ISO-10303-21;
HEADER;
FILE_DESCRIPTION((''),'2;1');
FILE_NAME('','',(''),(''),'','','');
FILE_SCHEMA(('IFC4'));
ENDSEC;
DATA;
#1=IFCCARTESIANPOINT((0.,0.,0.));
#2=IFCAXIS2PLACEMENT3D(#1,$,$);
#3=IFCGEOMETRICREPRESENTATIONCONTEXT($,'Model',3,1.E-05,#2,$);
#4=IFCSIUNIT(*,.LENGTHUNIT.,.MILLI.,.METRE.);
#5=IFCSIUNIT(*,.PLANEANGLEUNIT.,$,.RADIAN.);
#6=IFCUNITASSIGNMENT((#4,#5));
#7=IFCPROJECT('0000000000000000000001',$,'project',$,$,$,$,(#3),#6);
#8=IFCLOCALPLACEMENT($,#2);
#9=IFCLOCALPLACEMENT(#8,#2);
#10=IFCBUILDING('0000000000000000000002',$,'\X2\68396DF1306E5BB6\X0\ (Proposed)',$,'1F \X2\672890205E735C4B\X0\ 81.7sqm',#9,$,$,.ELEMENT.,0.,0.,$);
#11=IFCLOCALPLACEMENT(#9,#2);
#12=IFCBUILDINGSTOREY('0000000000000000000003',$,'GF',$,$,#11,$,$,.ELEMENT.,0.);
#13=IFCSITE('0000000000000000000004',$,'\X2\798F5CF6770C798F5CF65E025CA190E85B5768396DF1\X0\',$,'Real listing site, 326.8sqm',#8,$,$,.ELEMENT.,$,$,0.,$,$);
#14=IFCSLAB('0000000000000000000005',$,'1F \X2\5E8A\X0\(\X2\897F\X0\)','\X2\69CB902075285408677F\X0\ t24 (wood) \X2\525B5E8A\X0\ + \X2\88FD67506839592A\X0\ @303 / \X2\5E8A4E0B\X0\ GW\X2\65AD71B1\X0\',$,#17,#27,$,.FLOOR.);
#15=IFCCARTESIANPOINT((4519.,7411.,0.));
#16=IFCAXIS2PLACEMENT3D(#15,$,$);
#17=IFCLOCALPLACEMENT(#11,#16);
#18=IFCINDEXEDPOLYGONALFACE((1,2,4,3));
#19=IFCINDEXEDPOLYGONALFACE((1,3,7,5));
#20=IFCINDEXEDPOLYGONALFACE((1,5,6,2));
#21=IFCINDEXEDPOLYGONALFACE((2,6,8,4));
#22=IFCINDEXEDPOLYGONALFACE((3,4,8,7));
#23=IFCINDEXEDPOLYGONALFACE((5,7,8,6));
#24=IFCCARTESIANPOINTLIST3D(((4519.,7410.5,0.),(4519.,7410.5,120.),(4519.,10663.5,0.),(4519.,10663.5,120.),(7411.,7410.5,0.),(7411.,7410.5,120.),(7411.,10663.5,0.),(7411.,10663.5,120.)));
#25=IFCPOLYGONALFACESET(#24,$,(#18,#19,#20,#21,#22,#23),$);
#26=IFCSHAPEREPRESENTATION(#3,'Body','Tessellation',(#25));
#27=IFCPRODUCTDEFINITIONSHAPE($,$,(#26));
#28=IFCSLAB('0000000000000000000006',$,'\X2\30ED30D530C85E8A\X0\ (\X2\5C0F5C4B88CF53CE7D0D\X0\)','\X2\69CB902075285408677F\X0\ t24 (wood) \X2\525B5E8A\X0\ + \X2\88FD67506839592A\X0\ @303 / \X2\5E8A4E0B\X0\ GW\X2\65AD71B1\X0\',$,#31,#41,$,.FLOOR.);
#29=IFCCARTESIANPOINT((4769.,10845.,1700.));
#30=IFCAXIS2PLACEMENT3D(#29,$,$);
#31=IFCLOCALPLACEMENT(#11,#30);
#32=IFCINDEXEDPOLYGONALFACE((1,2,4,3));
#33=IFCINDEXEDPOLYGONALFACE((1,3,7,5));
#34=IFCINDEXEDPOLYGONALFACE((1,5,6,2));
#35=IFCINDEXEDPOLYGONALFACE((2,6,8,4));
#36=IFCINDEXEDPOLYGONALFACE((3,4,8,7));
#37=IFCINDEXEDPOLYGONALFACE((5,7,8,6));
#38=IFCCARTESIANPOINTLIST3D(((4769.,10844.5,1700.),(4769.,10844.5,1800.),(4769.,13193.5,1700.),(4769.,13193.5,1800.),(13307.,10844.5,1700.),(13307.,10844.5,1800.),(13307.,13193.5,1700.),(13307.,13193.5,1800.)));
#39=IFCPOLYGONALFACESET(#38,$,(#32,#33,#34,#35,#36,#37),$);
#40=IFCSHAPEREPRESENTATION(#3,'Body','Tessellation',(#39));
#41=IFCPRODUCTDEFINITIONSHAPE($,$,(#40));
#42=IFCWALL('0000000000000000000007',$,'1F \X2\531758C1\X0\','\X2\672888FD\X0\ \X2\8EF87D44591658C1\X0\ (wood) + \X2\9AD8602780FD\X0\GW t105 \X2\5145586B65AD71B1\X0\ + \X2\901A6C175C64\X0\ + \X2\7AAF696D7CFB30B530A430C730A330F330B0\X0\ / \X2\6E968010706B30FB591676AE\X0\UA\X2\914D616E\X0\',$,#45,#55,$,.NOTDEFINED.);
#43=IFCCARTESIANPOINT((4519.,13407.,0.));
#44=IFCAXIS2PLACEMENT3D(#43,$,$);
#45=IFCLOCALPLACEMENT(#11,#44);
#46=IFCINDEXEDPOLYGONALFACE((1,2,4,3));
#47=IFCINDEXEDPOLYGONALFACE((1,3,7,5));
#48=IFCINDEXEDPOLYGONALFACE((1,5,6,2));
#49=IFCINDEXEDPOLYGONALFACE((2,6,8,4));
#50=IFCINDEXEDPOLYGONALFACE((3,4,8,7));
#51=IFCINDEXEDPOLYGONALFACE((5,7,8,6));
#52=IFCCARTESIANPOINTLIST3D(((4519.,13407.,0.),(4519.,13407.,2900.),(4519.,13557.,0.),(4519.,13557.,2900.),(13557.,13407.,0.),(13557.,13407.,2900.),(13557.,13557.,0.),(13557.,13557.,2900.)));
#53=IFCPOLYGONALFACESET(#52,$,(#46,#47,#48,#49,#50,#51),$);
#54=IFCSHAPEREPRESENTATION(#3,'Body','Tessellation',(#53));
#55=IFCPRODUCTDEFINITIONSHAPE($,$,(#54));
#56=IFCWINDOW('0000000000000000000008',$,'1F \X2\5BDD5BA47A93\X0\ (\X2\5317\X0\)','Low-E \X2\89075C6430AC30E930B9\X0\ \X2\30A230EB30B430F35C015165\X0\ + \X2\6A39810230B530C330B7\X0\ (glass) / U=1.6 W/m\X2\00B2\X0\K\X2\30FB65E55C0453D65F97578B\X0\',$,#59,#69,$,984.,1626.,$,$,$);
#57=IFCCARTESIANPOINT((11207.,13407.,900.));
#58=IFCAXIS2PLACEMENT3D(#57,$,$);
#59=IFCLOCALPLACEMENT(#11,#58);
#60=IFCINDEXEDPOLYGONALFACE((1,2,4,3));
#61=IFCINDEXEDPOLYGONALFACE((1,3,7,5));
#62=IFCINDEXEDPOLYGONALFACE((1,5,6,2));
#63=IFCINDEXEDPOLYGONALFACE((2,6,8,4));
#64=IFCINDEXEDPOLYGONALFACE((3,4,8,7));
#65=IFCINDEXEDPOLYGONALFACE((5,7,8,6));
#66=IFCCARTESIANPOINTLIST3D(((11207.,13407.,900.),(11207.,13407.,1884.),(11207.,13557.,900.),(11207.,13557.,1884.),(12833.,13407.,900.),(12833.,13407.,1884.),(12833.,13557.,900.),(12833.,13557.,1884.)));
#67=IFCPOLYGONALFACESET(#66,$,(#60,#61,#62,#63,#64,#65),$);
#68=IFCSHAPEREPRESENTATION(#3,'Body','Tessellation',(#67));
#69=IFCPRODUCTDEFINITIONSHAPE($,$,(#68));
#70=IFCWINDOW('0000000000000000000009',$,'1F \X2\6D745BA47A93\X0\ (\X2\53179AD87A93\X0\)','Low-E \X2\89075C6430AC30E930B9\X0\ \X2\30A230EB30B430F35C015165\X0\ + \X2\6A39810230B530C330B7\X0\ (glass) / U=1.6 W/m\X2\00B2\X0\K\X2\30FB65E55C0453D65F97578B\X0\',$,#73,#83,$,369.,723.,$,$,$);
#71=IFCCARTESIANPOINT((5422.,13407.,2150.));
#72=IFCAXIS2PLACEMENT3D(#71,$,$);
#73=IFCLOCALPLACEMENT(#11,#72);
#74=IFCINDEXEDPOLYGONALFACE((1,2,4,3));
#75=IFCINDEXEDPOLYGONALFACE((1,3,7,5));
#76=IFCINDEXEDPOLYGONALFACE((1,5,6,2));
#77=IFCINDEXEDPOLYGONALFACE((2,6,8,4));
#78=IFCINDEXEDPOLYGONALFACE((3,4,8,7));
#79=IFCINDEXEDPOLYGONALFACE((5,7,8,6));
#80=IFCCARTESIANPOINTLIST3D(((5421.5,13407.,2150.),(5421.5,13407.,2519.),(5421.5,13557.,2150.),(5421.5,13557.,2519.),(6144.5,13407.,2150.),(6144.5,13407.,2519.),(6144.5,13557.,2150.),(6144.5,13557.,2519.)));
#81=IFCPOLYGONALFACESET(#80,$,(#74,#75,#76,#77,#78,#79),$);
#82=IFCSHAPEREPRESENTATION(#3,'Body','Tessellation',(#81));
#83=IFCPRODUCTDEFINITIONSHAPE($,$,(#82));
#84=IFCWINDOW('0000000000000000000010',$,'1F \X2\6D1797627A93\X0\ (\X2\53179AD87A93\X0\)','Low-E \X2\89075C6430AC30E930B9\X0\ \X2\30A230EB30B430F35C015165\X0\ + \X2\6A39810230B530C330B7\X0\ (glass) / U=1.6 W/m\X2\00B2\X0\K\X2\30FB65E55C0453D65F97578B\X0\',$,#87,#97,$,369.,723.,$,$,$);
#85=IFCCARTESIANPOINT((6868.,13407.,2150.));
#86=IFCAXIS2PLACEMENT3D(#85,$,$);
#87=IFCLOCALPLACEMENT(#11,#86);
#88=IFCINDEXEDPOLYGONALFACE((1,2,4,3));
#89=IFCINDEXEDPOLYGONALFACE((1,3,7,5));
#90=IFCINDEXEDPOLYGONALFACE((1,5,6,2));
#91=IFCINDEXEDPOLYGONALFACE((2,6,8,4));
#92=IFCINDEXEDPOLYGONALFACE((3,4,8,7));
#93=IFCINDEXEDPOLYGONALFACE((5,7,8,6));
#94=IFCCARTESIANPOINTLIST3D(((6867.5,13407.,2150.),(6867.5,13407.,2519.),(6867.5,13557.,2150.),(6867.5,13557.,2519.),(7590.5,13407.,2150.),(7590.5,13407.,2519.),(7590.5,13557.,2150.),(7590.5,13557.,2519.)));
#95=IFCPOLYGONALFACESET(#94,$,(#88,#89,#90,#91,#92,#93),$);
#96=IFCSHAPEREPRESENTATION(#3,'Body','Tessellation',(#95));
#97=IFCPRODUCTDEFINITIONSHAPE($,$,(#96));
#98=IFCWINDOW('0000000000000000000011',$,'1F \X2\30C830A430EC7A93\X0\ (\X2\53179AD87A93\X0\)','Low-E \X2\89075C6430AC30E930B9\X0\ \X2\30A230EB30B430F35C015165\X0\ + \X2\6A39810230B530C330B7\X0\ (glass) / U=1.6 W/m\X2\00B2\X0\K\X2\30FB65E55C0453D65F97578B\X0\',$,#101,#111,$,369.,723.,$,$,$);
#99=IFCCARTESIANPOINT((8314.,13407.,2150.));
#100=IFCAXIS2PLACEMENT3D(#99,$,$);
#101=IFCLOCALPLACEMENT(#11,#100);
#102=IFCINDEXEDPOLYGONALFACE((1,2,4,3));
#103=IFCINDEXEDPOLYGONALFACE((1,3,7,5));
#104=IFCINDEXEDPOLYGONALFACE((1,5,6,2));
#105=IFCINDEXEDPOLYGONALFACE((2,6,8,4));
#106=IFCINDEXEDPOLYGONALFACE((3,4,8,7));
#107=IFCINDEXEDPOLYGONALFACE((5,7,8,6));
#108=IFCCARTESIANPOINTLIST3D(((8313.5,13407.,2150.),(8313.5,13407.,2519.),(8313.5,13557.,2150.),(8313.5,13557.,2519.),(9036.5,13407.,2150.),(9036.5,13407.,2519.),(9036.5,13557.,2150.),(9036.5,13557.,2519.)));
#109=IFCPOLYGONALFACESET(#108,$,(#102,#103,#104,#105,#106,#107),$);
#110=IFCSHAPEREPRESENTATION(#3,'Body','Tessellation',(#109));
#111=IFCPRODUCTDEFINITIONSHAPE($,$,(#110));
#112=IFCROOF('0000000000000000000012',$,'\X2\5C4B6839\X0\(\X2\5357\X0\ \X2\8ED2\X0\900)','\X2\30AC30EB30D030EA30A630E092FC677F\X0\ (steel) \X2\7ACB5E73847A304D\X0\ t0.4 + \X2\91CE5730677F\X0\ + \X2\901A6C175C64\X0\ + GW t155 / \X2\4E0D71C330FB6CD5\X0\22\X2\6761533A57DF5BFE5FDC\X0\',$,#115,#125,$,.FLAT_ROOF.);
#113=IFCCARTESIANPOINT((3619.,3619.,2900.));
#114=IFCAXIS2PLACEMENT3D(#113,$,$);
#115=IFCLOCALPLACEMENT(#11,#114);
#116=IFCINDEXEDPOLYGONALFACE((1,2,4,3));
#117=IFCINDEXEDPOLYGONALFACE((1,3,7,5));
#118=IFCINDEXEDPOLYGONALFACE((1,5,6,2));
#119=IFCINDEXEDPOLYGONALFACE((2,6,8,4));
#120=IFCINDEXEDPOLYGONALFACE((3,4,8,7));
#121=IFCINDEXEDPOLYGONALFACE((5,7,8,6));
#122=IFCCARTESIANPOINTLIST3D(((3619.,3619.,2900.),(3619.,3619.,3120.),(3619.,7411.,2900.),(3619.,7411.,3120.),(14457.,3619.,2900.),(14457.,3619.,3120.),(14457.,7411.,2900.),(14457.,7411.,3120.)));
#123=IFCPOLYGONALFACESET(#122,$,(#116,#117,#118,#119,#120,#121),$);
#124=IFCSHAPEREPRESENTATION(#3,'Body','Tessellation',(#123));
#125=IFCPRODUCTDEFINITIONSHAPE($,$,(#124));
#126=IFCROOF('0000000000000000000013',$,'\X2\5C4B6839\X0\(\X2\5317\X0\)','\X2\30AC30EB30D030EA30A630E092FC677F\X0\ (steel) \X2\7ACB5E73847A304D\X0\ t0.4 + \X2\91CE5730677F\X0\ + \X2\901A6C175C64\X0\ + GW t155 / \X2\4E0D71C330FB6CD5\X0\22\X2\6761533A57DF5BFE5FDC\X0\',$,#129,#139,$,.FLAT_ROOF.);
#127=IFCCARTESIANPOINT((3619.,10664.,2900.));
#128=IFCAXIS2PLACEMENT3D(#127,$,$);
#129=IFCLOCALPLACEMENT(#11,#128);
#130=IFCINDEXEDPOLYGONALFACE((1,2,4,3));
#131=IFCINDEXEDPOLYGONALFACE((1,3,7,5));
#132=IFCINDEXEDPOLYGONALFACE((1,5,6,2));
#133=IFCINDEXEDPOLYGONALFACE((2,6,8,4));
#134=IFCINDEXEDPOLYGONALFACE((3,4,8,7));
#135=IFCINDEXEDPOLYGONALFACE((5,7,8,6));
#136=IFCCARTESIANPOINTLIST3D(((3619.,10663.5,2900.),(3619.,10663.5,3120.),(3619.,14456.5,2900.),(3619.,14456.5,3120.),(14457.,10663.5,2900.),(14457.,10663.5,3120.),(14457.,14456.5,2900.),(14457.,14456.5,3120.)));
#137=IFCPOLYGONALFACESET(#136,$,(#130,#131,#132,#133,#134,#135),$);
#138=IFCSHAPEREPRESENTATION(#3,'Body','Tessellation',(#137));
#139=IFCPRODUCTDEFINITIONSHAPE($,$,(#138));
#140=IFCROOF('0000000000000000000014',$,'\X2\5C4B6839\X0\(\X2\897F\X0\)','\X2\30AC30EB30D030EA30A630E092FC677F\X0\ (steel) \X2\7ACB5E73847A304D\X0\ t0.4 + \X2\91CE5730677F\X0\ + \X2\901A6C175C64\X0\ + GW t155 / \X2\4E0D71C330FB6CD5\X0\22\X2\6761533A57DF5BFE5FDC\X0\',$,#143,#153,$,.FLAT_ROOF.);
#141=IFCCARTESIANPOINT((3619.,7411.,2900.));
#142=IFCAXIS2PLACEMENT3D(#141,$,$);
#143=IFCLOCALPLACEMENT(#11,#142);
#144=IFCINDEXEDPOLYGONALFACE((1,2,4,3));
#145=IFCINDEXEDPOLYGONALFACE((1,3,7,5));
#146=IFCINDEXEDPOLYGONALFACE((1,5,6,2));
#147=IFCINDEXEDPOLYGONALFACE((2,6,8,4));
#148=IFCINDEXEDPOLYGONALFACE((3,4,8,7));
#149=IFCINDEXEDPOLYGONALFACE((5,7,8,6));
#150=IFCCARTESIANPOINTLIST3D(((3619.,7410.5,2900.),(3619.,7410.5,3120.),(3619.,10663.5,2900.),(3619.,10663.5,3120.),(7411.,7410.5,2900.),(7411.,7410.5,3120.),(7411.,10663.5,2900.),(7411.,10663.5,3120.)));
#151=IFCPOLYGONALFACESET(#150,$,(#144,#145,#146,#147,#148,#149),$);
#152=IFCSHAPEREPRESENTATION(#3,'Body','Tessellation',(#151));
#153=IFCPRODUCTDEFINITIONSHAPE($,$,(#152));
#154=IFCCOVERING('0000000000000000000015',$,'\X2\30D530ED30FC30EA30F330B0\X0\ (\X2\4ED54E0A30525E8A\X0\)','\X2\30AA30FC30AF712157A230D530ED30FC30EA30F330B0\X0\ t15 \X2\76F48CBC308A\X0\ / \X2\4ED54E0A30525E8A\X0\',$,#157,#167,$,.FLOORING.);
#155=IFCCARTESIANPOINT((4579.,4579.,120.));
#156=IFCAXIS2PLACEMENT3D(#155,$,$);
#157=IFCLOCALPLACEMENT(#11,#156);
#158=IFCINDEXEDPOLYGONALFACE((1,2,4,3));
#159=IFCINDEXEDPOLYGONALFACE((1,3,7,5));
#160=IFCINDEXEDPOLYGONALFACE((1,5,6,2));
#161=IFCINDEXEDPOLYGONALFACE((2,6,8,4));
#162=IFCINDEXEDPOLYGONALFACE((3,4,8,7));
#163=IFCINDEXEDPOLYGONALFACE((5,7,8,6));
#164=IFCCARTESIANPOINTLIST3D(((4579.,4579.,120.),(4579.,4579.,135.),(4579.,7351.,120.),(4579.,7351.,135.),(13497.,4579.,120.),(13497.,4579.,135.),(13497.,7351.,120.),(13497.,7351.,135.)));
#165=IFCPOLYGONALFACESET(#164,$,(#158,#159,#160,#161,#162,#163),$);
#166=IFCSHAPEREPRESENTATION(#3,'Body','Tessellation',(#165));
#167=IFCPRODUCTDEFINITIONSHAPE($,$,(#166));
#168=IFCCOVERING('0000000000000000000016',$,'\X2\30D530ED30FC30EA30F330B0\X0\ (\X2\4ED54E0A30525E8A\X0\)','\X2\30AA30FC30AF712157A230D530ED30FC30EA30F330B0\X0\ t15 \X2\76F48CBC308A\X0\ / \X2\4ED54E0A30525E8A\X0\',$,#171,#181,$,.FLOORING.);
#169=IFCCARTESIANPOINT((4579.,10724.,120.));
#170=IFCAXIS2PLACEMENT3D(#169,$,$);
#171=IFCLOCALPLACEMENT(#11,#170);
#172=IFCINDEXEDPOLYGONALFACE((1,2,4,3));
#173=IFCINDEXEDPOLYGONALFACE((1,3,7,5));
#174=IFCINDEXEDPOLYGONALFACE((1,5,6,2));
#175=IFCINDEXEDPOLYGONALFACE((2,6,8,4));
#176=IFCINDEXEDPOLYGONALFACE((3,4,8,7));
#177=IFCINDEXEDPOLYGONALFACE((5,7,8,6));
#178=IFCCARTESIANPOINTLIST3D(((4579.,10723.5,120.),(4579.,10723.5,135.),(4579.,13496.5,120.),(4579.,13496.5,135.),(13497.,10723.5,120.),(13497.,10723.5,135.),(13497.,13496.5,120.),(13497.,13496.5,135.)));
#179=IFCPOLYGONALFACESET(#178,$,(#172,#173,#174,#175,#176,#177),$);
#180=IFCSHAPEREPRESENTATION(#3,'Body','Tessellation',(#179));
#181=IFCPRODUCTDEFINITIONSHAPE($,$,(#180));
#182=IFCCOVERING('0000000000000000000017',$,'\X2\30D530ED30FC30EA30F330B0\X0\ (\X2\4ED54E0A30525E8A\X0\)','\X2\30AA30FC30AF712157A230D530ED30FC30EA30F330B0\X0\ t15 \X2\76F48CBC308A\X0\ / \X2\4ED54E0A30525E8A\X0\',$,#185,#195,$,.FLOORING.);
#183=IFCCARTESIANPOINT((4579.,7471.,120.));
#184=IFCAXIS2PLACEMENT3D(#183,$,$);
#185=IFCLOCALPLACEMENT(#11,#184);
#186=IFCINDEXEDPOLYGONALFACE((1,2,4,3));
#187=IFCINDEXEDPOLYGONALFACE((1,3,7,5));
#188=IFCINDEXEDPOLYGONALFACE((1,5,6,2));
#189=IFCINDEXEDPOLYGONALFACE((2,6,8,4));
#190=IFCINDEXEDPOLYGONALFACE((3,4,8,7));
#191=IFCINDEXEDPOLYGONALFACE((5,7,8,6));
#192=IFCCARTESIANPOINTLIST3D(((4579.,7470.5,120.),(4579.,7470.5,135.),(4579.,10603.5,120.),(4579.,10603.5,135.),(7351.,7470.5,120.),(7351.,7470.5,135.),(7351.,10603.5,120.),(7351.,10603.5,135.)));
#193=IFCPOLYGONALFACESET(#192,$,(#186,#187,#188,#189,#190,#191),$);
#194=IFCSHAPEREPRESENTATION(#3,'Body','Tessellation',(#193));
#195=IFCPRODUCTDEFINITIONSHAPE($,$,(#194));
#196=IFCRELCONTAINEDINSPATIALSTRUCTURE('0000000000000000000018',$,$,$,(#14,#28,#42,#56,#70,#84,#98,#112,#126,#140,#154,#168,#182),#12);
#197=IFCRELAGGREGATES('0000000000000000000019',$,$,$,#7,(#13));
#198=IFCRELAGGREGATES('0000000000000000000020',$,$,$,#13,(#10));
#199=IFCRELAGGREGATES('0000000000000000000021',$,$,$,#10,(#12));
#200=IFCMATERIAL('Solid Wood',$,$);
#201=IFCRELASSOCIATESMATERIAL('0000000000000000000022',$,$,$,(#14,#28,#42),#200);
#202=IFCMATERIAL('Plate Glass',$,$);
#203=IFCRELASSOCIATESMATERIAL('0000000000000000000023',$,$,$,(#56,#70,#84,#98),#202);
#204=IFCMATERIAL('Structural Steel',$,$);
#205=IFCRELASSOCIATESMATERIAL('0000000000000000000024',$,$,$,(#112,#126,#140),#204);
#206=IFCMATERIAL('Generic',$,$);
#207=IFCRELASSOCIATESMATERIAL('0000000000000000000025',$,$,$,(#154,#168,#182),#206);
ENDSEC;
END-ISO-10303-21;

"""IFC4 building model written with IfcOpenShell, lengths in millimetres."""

from ifc_helpers import new_model, si_unit, frame, frame_2d, origin, place, context, project, spatial, rectangle, extrude, material, element, fill, save


model = new_model("IFC4")

# Units and contexts
model_context = context("Model", 3, precision=1e-05, world=origin())
ifc_project = project(units=[si_unit("LENGTHUNIT", "METRE", prefix="MILLI"), si_unit("PLANEANGLEUNIT", "RADIAN")], contexts=[model_context])

# Site, building, storey
site_placement = place(None, origin())
site = spatial("IfcSite", under=ifc_project, at=site_placement, Name="福島県福島市岡部字根深", ObjectType="Real listing site, 326.8sqm", CompositionType="ELEMENT", RefElevation=0.0)
building_placement = place(site_placement, origin())
building = spatial("IfcBuilding", under=site, at=building_placement, Name="根深の家 (Proposed)", ObjectType="1F 木造平屋 81.7sqm", CompositionType="ELEMENT", ElevationOfRefHeight=0.0, ElevationOfTerrain=0.0)
storey_placement = place(building_placement, origin())
storey = spatial("IfcBuildingStorey", under=building, at=storey_placement, Name="GF", CompositionType="ELEMENT", Elevation=0.0)

# Slabs
ifc_material_1 = material(Name="Solid Wood")
slab_1_placement = place(storey_placement, frame((4519.0, 7411.0, 0.0)))
element("IfcSlab", 1, at=slab_1_placement, inside=storey, material=ifc_material_1, Name="1F 床(西)", Description="構造用合板 t24 (wood) 剛床 + 製材根太 @303 / 床下 GW断熱", PredefinedType="FLOOR", context=model_context, shape_type="SweptSolid", body=[
    extrude(rectangle(XDim=2892.0, YDim=3253.0, at=frame_2d((1446.0, 1626.0))), frame((4519.0, 7411.0, 0.0)), (0.0, 0.0, 1.0), 120.0),
])
slab_2_placement = place(storey_placement, frame((4769.0, 10845.0, 1700.0)))
element("IfcSlab", 2, at=slab_2_placement, inside=storey, material=ifc_material_1, Name="ロフト床 (小屋裏収納)", Description="構造用合板 t24 (wood) 剛床 + 製材根太 @303 / 床下 GW断熱", PredefinedType="FLOOR", context=model_context, shape_type="SweptSolid", body=[
    extrude(rectangle(XDim=8538.0, YDim=2349.0, at=frame_2d((4269.0, 1174.0))), frame((4769.0, 10845.0, 1700.0)), (0.0, 0.0, 1.0), 100.0),
])

# Shared definitions
ifc_material_2 = material(Name="Plate Glass")

# Wall, openings, windows
wall_1_placement = place(storey_placement, frame((4519.0, 13407.0, 0.0)))
wall_1 = element("IfcWall", 3, at=wall_1_placement, inside=storey, material=ifc_material_1, Name="1F 北壁", Description="木製 軸組外壁 (wood) + 高性能GW t105 充填断熱 + 通気層 + 窯業系サイディング / 準耐火・外皮UA配慮", PredefinedType="NOTDEFINED", context=model_context, shape_type="SweptSolid", body=[
    extrude(rectangle(XDim=9038.0, YDim=150.0, at=frame_2d((4519.0, 75.0))), frame((4519.0, 13407.0, 0.0)), (0.0, 0.0, 1.0), 2900.0),
])
opening_1_placement = place(storey_placement, frame((11207.0, 13407.0, 900.0)))
opening_1 = element("IfcOpeningElement", 4, at=opening_1_placement, cuts=wall_1, PredefinedType="NOTDEFINED", context=model_context, shape_type="SweptSolid", body=[
    extrude(rectangle(XDim=1626.0, YDim=150.0, at=frame_2d((813.0, 75.0))), frame((11207.0, 13407.0, 900.0)), (0.0, 0.0, 1.0), 984.0),
])
opening_2_placement = place(storey_placement, frame((5422.0, 13407.0, 2150.0)))
opening_2 = element("IfcOpeningElement", 5, at=opening_2_placement, cuts=wall_1, PredefinedType="NOTDEFINED", context=model_context, shape_type="SweptSolid", body=[
    extrude(rectangle(XDim=723.0, YDim=150.0, at=frame_2d((361.0, 75.0))), frame((5422.0, 13407.0, 2150.0)), (0.0, 0.0, 1.0), 369.0),
])
opening_3_placement = place(storey_placement, frame((6868.0, 13407.0, 2150.0)))
opening_3 = element("IfcOpeningElement", 6, at=opening_3_placement, cuts=wall_1, PredefinedType="NOTDEFINED", context=model_context, shape_type="SweptSolid", body=[
    extrude(rectangle(XDim=723.0, YDim=150.0, at=frame_2d((361.0, 75.0))), frame((6868.0, 13407.0, 2150.0)), (0.0, 0.0, 1.0), 369.0),
])
opening_4_placement = place(storey_placement, frame((8314.0, 13407.0, 2150.0)))
opening_4 = element("IfcOpeningElement", 7, at=opening_4_placement, cuts=wall_1, PredefinedType="NOTDEFINED", context=model_context, shape_type="SweptSolid", body=[
    extrude(rectangle(XDim=723.0, YDim=150.0, at=frame_2d((361.0, 75.0))), frame((8314.0, 13407.0, 2150.0)), (0.0, 0.0, 1.0), 369.0),
])
window_1_placement = place(storey_placement, frame((11207.0, 13407.0, 900.0)))
window_1 = element("IfcWindow", 8, at=window_1_placement, inside=storey, material=ifc_material_2, Name="1F 寝室窓 (北)", Description="Low-E 複層ガラス アルゴン封入 + 樹脂サッシ (glass) / U=1.6 W/m²K・日射取得型", OverallHeight=984.0, OverallWidth=1626.0, context=model_context, shape_type="SweptSolid", body=[
    extrude(rectangle(XDim=1626.0, YDim=150.0, at=frame_2d((813.0, 75.0))), frame((11207.0, 13407.0, 900.0)), (0.0, 0.0, 1.0), 984.0),
])
fill(opening_1, window_1)
window_2_placement = place(storey_placement, frame((5422.0, 13407.0, 2150.0)))
window_2 = element("IfcWindow", 9, at=window_2_placement, inside=storey, material=ifc_material_2, Name="1F 浴室窓 (北高窓)", Description="Low-E 複層ガラス アルゴン封入 + 樹脂サッシ (glass) / U=1.6 W/m²K・日射取得型", OverallHeight=369.0, OverallWidth=723.0, context=model_context, shape_type="SweptSolid", body=[
    extrude(rectangle(XDim=723.0, YDim=150.0, at=frame_2d((361.0, 75.0))), frame((5422.0, 13407.0, 2150.0)), (0.0, 0.0, 1.0), 369.0),
])
fill(opening_2, window_2)
window_3_placement = place(storey_placement, frame((6868.0, 13407.0, 2150.0)))
window_3 = element("IfcWindow", 10, at=window_3_placement, inside=storey, material=ifc_material_2, Name="1F 洗面窓 (北高窓)", Description="Low-E 複層ガラス アルゴン封入 + 樹脂サッシ (glass) / U=1.6 W/m²K・日射取得型", OverallHeight=369.0, OverallWidth=723.0, context=model_context, shape_type="SweptSolid", body=[
    extrude(rectangle(XDim=723.0, YDim=150.0, at=frame_2d((361.0, 75.0))), frame((6868.0, 13407.0, 2150.0)), (0.0, 0.0, 1.0), 369.0),
])
fill(opening_3, window_3)
window_4_placement = place(storey_placement, frame((8314.0, 13407.0, 2150.0)))
window_4 = element("IfcWindow", 11, at=window_4_placement, inside=storey, material=ifc_material_2, Name="1F トイレ窓 (北高窓)", Description="Low-E 複層ガラス アルゴン封入 + 樹脂サッシ (glass) / U=1.6 W/m²K・日射取得型", OverallHeight=369.0, OverallWidth=723.0, context=model_context, shape_type="SweptSolid", body=[
    extrude(rectangle(XDim=723.0, YDim=150.0, at=frame_2d((361.0, 75.0))), frame((8314.0, 13407.0, 2150.0)), (0.0, 0.0, 1.0), 369.0),
])
fill(opening_4, window_4)

# Roofs
ifc_material_3 = material(Name="Structural Steel")
roof_1_placement = place(storey_placement, frame((3619.0, 3619.0, 2900.0)))
element("IfcRoof", 12, at=roof_1_placement, inside=storey, material=ifc_material_3, Name="屋根(南 軒900)", Description="ガルバリウム鋼板 (steel) 立平葺き t0.4 + 野地板 + 通気層 + GW t155 / 不燃・法22条区域対応", PredefinedType="FLAT_ROOF", context=model_context, shape_type="SweptSolid", body=[
    extrude(rectangle(XDim=10838.0, YDim=3792.0, at=frame_2d((5419.0, 1896.0))), frame((3619.0, 3619.0, 2900.0)), (0.0, 0.0, 1.0), 220.0),
])
roof_2_placement = place(storey_placement, frame((3619.0, 10664.0, 2900.0)))
element("IfcRoof", 13, at=roof_2_placement, inside=storey, material=ifc_material_3, Name="屋根(北)", Description="ガルバリウム鋼板 (steel) 立平葺き t0.4 + 野地板 + 通気層 + GW t155 / 不燃・法22条区域対応", PredefinedType="FLAT_ROOF", context=model_context, shape_type="SweptSolid", body=[
    extrude(rectangle(XDim=10838.0, YDim=3793.0, at=frame_2d((5419.0, 1896.0))), frame((3619.0, 10664.0, 2900.0)), (0.0, 0.0, 1.0), 220.0),
])
roof_3_placement = place(storey_placement, frame((3619.0, 7411.0, 2900.0)))
element("IfcRoof", 14, at=roof_3_placement, inside=storey, material=ifc_material_3, Name="屋根(西)", Description="ガルバリウム鋼板 (steel) 立平葺き t0.4 + 野地板 + 通気層 + GW t155 / 不燃・法22条区域対応", PredefinedType="FLAT_ROOF", context=model_context, shape_type="SweptSolid", body=[
    extrude(rectangle(XDim=3792.0, YDim=3253.0, at=frame_2d((1896.0, 1626.0))), frame((3619.0, 7411.0, 2900.0)), (0.0, 0.0, 1.0), 220.0),
])

# Coverings
ifc_material_4 = material(Name="Generic")
covering_1_placement = place(storey_placement, frame((4579.0, 4579.0, 120.0)))
element("IfcCovering", 15, at=covering_1_placement, inside=storey, material=ifc_material_4, Name="フローリング (仕上げ床)", Description="オーク無垢フローリング t15 直貼り / 仕上げ床", PredefinedType="FLOORING", context=model_context, shape_type="SweptSolid", body=[
    extrude(rectangle(XDim=8918.0, YDim=2772.0, at=frame_2d((4459.0, 1386.0))), frame((4579.0, 4579.0, 120.0)), (0.0, 0.0, 1.0), 15.0),
])
covering_2_placement = place(storey_placement, frame((4579.0, 10724.0, 120.0)))
element("IfcCovering", 16, at=covering_2_placement, inside=storey, material=ifc_material_4, Name="フローリング (仕上げ床)", Description="オーク無垢フローリング t15 直貼り / 仕上げ床", PredefinedType="FLOORING", context=model_context, shape_type="SweptSolid", body=[
    extrude(rectangle(XDim=8918.0, YDim=2773.0, at=frame_2d((4459.0, 1386.0))), frame((4579.0, 10724.0, 120.0)), (0.0, 0.0, 1.0), 15.0),
])
covering_3_placement = place(storey_placement, frame((4579.0, 7471.0, 120.0)))
element("IfcCovering", 17, at=covering_3_placement, inside=storey, material=ifc_material_4, Name="フローリング (仕上げ床)", Description="オーク無垢フローリング t15 直貼り / 仕上げ床", PredefinedType="FLOORING", context=model_context, shape_type="SweptSolid", body=[
    extrude(rectangle(XDim=2772.0, YDim=3133.0, at=frame_2d((1386.0, 1566.0))), frame((4579.0, 7471.0, 120.0)), (0.0, 0.0, 1.0), 15.0),
])

save(model, "model.ifc")
